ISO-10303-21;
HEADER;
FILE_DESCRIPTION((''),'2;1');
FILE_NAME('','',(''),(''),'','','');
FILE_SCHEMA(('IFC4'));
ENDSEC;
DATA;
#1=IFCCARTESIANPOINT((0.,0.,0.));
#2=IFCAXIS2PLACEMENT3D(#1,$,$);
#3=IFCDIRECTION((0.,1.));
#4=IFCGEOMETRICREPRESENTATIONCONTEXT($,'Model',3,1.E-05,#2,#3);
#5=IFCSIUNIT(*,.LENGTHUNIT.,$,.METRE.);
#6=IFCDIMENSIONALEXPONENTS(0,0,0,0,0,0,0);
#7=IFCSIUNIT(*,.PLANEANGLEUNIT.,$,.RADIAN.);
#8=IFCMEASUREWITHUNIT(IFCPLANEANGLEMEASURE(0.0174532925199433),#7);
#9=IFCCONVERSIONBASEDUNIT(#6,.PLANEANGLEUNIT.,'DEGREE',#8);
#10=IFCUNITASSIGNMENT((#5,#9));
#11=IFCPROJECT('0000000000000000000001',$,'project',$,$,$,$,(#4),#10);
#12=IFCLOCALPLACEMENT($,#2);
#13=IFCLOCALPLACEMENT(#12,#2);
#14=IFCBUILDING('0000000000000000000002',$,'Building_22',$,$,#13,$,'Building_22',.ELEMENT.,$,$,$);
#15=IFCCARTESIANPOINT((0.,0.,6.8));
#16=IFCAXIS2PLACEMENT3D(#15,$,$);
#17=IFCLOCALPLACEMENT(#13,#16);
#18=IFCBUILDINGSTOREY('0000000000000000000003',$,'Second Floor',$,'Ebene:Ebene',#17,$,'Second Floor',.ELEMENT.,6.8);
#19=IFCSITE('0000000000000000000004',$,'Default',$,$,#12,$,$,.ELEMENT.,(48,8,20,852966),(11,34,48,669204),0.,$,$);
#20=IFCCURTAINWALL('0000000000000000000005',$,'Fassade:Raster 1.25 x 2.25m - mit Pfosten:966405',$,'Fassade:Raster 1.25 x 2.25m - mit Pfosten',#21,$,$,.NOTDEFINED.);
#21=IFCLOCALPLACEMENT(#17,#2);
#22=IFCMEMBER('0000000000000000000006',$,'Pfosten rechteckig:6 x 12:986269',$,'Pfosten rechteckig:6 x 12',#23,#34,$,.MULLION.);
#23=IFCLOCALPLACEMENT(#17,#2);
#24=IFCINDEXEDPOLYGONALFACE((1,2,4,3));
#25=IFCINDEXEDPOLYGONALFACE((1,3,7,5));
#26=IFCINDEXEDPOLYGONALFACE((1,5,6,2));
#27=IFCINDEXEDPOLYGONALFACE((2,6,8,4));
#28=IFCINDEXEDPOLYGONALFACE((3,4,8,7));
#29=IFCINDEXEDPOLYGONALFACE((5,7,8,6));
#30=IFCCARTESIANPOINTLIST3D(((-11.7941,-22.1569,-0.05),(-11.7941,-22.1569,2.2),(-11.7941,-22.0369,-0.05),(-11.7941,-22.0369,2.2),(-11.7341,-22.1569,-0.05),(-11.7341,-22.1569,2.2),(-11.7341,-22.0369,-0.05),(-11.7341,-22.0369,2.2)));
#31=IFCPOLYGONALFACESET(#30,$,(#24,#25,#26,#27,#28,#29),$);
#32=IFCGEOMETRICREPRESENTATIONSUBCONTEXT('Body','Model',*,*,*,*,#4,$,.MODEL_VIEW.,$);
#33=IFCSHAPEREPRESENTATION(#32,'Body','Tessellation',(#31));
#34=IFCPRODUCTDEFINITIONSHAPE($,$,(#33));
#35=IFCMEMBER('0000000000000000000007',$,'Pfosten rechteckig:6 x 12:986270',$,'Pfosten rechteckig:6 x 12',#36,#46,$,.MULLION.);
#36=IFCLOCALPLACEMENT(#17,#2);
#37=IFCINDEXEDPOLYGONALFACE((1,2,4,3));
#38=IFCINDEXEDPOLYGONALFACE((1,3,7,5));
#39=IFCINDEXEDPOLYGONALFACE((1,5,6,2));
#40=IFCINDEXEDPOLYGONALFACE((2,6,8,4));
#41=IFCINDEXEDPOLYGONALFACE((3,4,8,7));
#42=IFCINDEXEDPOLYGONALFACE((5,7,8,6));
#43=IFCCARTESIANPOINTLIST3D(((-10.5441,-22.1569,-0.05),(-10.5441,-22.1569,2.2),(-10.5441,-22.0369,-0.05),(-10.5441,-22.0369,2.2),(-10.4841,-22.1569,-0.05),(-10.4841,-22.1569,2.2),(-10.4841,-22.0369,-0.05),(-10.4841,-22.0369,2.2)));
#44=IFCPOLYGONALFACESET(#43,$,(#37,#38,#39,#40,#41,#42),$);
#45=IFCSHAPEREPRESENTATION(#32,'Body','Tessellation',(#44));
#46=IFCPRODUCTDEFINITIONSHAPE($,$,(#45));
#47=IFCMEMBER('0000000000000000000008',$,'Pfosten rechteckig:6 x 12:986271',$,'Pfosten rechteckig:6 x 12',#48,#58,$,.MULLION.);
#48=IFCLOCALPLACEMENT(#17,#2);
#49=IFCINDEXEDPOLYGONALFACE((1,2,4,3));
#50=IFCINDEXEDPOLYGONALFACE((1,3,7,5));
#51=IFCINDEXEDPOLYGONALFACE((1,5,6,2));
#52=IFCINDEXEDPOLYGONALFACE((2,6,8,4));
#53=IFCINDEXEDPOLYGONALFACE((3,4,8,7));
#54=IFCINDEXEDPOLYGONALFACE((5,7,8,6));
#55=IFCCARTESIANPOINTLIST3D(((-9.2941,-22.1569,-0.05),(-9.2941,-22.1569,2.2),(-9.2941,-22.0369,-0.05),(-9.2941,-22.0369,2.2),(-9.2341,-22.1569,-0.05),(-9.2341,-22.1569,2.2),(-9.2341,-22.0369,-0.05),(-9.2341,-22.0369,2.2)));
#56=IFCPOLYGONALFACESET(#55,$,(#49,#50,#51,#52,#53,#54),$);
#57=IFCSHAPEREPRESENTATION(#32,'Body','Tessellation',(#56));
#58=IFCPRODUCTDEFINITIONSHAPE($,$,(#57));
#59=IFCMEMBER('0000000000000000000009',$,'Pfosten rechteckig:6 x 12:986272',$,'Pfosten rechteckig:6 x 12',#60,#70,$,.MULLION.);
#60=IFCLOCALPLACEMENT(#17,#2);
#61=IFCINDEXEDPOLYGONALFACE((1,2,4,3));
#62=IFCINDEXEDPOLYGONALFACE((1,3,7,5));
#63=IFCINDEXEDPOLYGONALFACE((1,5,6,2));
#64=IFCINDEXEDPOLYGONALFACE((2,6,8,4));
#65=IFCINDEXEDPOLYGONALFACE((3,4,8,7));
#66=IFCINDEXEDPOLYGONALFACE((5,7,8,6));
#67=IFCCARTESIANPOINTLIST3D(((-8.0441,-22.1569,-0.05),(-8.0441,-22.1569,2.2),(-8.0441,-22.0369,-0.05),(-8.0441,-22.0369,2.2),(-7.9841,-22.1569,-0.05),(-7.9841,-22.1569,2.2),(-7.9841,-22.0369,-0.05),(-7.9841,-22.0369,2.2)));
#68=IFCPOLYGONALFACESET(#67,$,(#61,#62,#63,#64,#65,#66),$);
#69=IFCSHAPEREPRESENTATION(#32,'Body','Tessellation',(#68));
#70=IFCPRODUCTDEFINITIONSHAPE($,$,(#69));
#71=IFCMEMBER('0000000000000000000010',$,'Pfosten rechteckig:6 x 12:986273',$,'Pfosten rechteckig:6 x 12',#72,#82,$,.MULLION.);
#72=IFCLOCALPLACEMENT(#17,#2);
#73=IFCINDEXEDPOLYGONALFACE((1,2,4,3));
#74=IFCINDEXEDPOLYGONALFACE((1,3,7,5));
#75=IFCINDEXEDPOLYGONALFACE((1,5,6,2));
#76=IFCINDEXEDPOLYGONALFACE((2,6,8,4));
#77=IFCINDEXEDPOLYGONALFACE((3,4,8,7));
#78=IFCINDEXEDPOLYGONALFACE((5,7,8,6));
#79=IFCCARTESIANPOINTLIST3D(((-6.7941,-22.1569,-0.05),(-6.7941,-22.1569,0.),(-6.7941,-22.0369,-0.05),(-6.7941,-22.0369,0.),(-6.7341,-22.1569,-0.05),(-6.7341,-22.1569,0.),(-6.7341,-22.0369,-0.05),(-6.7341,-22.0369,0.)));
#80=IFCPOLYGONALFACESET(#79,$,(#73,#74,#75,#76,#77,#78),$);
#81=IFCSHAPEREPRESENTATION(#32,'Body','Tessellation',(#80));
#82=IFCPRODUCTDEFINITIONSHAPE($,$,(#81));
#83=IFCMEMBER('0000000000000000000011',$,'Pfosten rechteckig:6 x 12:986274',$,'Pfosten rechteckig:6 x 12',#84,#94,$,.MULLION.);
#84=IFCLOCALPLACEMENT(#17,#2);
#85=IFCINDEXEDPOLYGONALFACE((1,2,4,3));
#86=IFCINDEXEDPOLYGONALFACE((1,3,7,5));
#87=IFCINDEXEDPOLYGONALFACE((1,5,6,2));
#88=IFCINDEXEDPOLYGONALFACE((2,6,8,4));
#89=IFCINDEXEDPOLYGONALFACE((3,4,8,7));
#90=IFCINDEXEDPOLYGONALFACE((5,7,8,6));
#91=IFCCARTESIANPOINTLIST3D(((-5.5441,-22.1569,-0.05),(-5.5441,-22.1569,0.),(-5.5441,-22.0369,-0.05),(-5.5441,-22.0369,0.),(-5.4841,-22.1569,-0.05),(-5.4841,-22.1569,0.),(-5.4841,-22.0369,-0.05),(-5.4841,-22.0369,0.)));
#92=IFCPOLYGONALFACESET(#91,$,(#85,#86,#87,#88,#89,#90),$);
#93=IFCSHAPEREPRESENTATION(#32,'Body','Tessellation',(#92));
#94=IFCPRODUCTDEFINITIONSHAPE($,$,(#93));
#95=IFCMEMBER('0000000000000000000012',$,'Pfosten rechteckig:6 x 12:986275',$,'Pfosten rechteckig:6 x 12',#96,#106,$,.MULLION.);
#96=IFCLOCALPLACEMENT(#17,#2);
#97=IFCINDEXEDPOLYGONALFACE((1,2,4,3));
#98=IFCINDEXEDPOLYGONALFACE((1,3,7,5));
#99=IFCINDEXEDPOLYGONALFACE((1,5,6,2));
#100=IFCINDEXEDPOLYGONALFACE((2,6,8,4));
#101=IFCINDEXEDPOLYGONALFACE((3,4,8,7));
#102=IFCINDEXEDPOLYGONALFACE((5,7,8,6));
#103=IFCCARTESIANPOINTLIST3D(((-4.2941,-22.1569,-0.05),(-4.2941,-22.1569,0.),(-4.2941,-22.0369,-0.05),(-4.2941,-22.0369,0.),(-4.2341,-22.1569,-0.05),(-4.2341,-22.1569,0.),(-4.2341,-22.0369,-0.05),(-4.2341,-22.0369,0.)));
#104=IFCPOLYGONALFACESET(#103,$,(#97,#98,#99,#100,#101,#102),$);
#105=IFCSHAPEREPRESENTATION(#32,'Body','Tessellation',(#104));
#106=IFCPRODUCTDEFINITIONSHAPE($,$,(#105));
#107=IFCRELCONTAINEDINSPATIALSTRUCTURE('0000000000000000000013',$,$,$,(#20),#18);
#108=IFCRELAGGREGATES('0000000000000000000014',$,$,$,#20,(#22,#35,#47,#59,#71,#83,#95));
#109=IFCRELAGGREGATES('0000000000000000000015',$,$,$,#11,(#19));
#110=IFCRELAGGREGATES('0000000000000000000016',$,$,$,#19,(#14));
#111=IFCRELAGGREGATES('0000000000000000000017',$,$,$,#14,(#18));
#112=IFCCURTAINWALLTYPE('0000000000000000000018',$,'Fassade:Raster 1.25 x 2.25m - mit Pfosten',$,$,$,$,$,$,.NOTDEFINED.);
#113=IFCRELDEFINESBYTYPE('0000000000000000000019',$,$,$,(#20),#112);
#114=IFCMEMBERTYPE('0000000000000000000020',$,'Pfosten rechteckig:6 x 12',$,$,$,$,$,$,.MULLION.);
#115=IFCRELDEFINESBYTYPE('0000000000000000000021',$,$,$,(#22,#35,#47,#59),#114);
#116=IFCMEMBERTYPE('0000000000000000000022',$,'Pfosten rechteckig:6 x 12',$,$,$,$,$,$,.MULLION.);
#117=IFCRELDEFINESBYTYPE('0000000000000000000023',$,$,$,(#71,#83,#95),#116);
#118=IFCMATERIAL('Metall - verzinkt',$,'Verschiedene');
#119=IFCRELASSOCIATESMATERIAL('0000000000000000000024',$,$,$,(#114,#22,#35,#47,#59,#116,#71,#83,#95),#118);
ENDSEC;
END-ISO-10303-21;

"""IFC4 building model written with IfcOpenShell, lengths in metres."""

from ifc_helpers import new_model, entity, si_unit, converted_unit, direction, frame, origin, place, context, subcontext, project, spatial, indexed_curve, outline, extrude, source, transform, mapped, material, type_object, type_shapes, element, aggregate, save


model = new_model("IFC4")

# Units and contexts
model_context = context("Model", 3, precision=1e-05, world=origin(), true_north=direction((0.0, 1.0)))
body_context = subcontext(model_context, "Body", "Model", "MODEL_VIEW")
ifc_project = project(units=[si_unit("LENGTHUNIT", "METRE"), converted_unit("PLANEANGLEUNIT", "DEGREE", entity("IfcPlaneAngleMeasure", 0.0174532925199433), si_unit("PLANEANGLEUNIT", "RADIAN"), dimensions=[0, 0, 0, 0, 0, 0, 0])], contexts=[model_context])

# Site, building, storey
site_placement = place(None, origin())
site = spatial("IfcSite", under=ifc_project, at=site_placement, Name="Default", CompositionType="ELEMENT", RefLatitude=(48, 8, 20, 852966), RefLongitude=(11, 34, 48, 669204), RefElevation=0.0)
building_placement = place(site_placement, origin())
building = spatial("IfcBuilding", under=site, at=building_placement, Name="Building_22", LongName="Building_22", CompositionType="ELEMENT")
storey_placement = place(building_placement, frame((0.0, 0.0, 6.8)))
storey = spatial("IfcBuildingStorey", under=building, at=storey_placement, Name="Second Floor", ObjectType="Ebene:Ebene", LongName="Second Floor", CompositionType="ELEMENT", Elevation=6.8)

# Curtain wall, members
curtain_wall_type = type_object("IfcCurtainWallType", Name="Fassade:Raster 1.25 x 2.25m - mit Pfosten", PredefinedType="NOTDEFINED")
curtain_wall_placement = place(storey_placement, frame((0.0, 0.0, -6.8)))
curtain_wall = element("IfcCurtainWall", 1, at=curtain_wall_placement, inside=storey, type_object=curtain_wall_type, Name="Fassade:Raster 1.25 x 2.25m - mit Pfosten:966405", ObjectType="Fassade:Raster 1.25 x 2.25m - mit Pfosten", PredefinedType="NOTDEFINED")
ifc_material = material(Name="Metall - verzinkt", Category="Verschiedene")
member_type_1 = type_object("IfcMemberType", Name="Pfosten rechteckig:6 x 12", PredefinedType="MULLION", material=ifc_material)
shared_shape_1 = source(origin(), body_context, "Body", "SweptSolid", [
    extrude(outline(indexed_curve([(-0.03, -0.06), (0.03, -0.06), (0.03, 0.06), (-0.03, 0.06), (-0.03, -0.06)], self_intersect=False)), frame((0.0, 0.0, -2.25), z_axis=(0.0, 0.0, 1.0), x_axis=(-1.0, 0.0, 0.0)), (0.0, 0.0, 1.0), 2.25),
])
type_shapes(member_type_1, [shared_shape_1])
member_1_placement = place(curtain_wall_placement, frame((-11.7641, -22.0969, 6.75), z_axis=(0.0, 0.0, -1.0), x_axis=(1.0, 0.0, 0.0)))
member_1 = element("IfcMember", 2, at=member_1_placement, type_object=member_type_1, material=ifc_material, Name="Pfosten rechteckig:6 x 12:986269", ObjectType="Pfosten rechteckig:6 x 12", PredefinedType="MULLION", context=body_context, shape_type="MappedRepresentation", body=[
    mapped(shared_shape_1, transform((0.0, 0.0, 0.0), scale=1.0)),
])
member_2_placement = place(curtain_wall_placement, frame((-10.5141, -22.0969, 6.75), z_axis=(0.0, 0.0, -1.0), x_axis=(1.0, 0.0, 0.0)))
member_2 = element("IfcMember", 3, at=member_2_placement, type_object=member_type_1, material=ifc_material, Name="Pfosten rechteckig:6 x 12:986270", ObjectType="Pfosten rechteckig:6 x 12", PredefinedType="MULLION", context=body_context, shape_type="MappedRepresentation", body=[
    mapped(shared_shape_1, transform((0.0, 0.0, 0.0), scale=1.0)),
])
member_3_placement = place(curtain_wall_placement, frame((-9.2641, -22.0969, 6.75), z_axis=(0.0, 0.0, -1.0), x_axis=(1.0, 0.0, 0.0)))
member_3 = element("IfcMember", 4, at=member_3_placement, type_object=member_type_1, material=ifc_material, Name="Pfosten rechteckig:6 x 12:986271", ObjectType="Pfosten rechteckig:6 x 12", PredefinedType="MULLION", context=body_context, shape_type="MappedRepresentation", body=[
    mapped(shared_shape_1, transform((0.0, 0.0, 0.0), scale=1.0)),
])
member_4_placement = place(curtain_wall_placement, frame((-8.0141, -22.0969, 6.75), z_axis=(0.0, 0.0, -1.0), x_axis=(1.0, 0.0, 0.0)))
member_4 = element("IfcMember", 5, at=member_4_placement, type_object=member_type_1, material=ifc_material, Name="Pfosten rechteckig:6 x 12:986272", ObjectType="Pfosten rechteckig:6 x 12", PredefinedType="MULLION", context=body_context, shape_type="MappedRepresentation", body=[
    mapped(shared_shape_1, transform((0.0, 0.0, 0.0), scale=1.0)),
])
member_type_2 = type_object("IfcMemberType", Name="Pfosten rechteckig:6 x 12", PredefinedType="MULLION", material=ifc_material)
shared_shape_2 = source(origin(), body_context, "Body", "SweptSolid", [
    extrude(outline(indexed_curve([(-0.03, -0.06), (0.03, -0.06), (0.03, 0.06), (-0.03, 0.06), (-0.03, -0.06)], self_intersect=False)), frame((0.0, 0.0, -0.05), z_axis=(0.0, 0.0, 1.0), x_axis=(-1.0, 0.0, 0.0)), (0.0, 0.0, 1.0), 0.05),
])
type_shapes(member_type_2, [shared_shape_2])
member_5_placement = place(curtain_wall_placement, frame((-6.7641, -22.0969, 6.75), z_axis=(0.0, 0.0, -1.0), x_axis=(1.0, 0.0, 0.0)))
member_5 = element("IfcMember", 6, at=member_5_placement, type_object=member_type_2, material=ifc_material, Name="Pfosten rechteckig:6 x 12:986273", ObjectType="Pfosten rechteckig:6 x 12", PredefinedType="MULLION", context=body_context, shape_type="MappedRepresentation", body=[
    mapped(shared_shape_2, transform((0.0, 0.0, 0.0), scale=1.0)),
])
member_6_placement = place(curtain_wall_placement, frame((-5.5141, -22.0969, 6.75), z_axis=(0.0, 0.0, -1.0), x_axis=(1.0, 0.0, 0.0)))
member_6 = element("IfcMember", 7, at=member_6_placement, type_object=member_type_2, material=ifc_material, Name="Pfosten rechteckig:6 x 12:986274", ObjectType="Pfosten rechteckig:6 x 12", PredefinedType="MULLION", context=body_context, shape_type="MappedRepresentation", body=[
    mapped(shared_shape_2, transform((0.0, 0.0, 0.0), scale=1.0)),
])
member_7_placement = place(curtain_wall_placement, frame((-4.2641, -22.0969, 6.75), z_axis=(0.0, 0.0, -1.0), x_axis=(1.0, 0.0, 0.0)))
member_7 = element("IfcMember", 8, at=member_7_placement, type_object=member_type_2, material=ifc_material, Name="Pfosten rechteckig:6 x 12:986275", ObjectType="Pfosten rechteckig:6 x 12", PredefinedType="MULLION", context=body_context, shape_type="MappedRepresentation", body=[
    mapped(shared_shape_2, transform((0.0, 0.0, 0.0), scale=1.0)),
])
aggregate(curtain_wall, [member_1, member_2, member_3, member_4, member_5, member_6, member_7])

save(model, "model.ifc")
